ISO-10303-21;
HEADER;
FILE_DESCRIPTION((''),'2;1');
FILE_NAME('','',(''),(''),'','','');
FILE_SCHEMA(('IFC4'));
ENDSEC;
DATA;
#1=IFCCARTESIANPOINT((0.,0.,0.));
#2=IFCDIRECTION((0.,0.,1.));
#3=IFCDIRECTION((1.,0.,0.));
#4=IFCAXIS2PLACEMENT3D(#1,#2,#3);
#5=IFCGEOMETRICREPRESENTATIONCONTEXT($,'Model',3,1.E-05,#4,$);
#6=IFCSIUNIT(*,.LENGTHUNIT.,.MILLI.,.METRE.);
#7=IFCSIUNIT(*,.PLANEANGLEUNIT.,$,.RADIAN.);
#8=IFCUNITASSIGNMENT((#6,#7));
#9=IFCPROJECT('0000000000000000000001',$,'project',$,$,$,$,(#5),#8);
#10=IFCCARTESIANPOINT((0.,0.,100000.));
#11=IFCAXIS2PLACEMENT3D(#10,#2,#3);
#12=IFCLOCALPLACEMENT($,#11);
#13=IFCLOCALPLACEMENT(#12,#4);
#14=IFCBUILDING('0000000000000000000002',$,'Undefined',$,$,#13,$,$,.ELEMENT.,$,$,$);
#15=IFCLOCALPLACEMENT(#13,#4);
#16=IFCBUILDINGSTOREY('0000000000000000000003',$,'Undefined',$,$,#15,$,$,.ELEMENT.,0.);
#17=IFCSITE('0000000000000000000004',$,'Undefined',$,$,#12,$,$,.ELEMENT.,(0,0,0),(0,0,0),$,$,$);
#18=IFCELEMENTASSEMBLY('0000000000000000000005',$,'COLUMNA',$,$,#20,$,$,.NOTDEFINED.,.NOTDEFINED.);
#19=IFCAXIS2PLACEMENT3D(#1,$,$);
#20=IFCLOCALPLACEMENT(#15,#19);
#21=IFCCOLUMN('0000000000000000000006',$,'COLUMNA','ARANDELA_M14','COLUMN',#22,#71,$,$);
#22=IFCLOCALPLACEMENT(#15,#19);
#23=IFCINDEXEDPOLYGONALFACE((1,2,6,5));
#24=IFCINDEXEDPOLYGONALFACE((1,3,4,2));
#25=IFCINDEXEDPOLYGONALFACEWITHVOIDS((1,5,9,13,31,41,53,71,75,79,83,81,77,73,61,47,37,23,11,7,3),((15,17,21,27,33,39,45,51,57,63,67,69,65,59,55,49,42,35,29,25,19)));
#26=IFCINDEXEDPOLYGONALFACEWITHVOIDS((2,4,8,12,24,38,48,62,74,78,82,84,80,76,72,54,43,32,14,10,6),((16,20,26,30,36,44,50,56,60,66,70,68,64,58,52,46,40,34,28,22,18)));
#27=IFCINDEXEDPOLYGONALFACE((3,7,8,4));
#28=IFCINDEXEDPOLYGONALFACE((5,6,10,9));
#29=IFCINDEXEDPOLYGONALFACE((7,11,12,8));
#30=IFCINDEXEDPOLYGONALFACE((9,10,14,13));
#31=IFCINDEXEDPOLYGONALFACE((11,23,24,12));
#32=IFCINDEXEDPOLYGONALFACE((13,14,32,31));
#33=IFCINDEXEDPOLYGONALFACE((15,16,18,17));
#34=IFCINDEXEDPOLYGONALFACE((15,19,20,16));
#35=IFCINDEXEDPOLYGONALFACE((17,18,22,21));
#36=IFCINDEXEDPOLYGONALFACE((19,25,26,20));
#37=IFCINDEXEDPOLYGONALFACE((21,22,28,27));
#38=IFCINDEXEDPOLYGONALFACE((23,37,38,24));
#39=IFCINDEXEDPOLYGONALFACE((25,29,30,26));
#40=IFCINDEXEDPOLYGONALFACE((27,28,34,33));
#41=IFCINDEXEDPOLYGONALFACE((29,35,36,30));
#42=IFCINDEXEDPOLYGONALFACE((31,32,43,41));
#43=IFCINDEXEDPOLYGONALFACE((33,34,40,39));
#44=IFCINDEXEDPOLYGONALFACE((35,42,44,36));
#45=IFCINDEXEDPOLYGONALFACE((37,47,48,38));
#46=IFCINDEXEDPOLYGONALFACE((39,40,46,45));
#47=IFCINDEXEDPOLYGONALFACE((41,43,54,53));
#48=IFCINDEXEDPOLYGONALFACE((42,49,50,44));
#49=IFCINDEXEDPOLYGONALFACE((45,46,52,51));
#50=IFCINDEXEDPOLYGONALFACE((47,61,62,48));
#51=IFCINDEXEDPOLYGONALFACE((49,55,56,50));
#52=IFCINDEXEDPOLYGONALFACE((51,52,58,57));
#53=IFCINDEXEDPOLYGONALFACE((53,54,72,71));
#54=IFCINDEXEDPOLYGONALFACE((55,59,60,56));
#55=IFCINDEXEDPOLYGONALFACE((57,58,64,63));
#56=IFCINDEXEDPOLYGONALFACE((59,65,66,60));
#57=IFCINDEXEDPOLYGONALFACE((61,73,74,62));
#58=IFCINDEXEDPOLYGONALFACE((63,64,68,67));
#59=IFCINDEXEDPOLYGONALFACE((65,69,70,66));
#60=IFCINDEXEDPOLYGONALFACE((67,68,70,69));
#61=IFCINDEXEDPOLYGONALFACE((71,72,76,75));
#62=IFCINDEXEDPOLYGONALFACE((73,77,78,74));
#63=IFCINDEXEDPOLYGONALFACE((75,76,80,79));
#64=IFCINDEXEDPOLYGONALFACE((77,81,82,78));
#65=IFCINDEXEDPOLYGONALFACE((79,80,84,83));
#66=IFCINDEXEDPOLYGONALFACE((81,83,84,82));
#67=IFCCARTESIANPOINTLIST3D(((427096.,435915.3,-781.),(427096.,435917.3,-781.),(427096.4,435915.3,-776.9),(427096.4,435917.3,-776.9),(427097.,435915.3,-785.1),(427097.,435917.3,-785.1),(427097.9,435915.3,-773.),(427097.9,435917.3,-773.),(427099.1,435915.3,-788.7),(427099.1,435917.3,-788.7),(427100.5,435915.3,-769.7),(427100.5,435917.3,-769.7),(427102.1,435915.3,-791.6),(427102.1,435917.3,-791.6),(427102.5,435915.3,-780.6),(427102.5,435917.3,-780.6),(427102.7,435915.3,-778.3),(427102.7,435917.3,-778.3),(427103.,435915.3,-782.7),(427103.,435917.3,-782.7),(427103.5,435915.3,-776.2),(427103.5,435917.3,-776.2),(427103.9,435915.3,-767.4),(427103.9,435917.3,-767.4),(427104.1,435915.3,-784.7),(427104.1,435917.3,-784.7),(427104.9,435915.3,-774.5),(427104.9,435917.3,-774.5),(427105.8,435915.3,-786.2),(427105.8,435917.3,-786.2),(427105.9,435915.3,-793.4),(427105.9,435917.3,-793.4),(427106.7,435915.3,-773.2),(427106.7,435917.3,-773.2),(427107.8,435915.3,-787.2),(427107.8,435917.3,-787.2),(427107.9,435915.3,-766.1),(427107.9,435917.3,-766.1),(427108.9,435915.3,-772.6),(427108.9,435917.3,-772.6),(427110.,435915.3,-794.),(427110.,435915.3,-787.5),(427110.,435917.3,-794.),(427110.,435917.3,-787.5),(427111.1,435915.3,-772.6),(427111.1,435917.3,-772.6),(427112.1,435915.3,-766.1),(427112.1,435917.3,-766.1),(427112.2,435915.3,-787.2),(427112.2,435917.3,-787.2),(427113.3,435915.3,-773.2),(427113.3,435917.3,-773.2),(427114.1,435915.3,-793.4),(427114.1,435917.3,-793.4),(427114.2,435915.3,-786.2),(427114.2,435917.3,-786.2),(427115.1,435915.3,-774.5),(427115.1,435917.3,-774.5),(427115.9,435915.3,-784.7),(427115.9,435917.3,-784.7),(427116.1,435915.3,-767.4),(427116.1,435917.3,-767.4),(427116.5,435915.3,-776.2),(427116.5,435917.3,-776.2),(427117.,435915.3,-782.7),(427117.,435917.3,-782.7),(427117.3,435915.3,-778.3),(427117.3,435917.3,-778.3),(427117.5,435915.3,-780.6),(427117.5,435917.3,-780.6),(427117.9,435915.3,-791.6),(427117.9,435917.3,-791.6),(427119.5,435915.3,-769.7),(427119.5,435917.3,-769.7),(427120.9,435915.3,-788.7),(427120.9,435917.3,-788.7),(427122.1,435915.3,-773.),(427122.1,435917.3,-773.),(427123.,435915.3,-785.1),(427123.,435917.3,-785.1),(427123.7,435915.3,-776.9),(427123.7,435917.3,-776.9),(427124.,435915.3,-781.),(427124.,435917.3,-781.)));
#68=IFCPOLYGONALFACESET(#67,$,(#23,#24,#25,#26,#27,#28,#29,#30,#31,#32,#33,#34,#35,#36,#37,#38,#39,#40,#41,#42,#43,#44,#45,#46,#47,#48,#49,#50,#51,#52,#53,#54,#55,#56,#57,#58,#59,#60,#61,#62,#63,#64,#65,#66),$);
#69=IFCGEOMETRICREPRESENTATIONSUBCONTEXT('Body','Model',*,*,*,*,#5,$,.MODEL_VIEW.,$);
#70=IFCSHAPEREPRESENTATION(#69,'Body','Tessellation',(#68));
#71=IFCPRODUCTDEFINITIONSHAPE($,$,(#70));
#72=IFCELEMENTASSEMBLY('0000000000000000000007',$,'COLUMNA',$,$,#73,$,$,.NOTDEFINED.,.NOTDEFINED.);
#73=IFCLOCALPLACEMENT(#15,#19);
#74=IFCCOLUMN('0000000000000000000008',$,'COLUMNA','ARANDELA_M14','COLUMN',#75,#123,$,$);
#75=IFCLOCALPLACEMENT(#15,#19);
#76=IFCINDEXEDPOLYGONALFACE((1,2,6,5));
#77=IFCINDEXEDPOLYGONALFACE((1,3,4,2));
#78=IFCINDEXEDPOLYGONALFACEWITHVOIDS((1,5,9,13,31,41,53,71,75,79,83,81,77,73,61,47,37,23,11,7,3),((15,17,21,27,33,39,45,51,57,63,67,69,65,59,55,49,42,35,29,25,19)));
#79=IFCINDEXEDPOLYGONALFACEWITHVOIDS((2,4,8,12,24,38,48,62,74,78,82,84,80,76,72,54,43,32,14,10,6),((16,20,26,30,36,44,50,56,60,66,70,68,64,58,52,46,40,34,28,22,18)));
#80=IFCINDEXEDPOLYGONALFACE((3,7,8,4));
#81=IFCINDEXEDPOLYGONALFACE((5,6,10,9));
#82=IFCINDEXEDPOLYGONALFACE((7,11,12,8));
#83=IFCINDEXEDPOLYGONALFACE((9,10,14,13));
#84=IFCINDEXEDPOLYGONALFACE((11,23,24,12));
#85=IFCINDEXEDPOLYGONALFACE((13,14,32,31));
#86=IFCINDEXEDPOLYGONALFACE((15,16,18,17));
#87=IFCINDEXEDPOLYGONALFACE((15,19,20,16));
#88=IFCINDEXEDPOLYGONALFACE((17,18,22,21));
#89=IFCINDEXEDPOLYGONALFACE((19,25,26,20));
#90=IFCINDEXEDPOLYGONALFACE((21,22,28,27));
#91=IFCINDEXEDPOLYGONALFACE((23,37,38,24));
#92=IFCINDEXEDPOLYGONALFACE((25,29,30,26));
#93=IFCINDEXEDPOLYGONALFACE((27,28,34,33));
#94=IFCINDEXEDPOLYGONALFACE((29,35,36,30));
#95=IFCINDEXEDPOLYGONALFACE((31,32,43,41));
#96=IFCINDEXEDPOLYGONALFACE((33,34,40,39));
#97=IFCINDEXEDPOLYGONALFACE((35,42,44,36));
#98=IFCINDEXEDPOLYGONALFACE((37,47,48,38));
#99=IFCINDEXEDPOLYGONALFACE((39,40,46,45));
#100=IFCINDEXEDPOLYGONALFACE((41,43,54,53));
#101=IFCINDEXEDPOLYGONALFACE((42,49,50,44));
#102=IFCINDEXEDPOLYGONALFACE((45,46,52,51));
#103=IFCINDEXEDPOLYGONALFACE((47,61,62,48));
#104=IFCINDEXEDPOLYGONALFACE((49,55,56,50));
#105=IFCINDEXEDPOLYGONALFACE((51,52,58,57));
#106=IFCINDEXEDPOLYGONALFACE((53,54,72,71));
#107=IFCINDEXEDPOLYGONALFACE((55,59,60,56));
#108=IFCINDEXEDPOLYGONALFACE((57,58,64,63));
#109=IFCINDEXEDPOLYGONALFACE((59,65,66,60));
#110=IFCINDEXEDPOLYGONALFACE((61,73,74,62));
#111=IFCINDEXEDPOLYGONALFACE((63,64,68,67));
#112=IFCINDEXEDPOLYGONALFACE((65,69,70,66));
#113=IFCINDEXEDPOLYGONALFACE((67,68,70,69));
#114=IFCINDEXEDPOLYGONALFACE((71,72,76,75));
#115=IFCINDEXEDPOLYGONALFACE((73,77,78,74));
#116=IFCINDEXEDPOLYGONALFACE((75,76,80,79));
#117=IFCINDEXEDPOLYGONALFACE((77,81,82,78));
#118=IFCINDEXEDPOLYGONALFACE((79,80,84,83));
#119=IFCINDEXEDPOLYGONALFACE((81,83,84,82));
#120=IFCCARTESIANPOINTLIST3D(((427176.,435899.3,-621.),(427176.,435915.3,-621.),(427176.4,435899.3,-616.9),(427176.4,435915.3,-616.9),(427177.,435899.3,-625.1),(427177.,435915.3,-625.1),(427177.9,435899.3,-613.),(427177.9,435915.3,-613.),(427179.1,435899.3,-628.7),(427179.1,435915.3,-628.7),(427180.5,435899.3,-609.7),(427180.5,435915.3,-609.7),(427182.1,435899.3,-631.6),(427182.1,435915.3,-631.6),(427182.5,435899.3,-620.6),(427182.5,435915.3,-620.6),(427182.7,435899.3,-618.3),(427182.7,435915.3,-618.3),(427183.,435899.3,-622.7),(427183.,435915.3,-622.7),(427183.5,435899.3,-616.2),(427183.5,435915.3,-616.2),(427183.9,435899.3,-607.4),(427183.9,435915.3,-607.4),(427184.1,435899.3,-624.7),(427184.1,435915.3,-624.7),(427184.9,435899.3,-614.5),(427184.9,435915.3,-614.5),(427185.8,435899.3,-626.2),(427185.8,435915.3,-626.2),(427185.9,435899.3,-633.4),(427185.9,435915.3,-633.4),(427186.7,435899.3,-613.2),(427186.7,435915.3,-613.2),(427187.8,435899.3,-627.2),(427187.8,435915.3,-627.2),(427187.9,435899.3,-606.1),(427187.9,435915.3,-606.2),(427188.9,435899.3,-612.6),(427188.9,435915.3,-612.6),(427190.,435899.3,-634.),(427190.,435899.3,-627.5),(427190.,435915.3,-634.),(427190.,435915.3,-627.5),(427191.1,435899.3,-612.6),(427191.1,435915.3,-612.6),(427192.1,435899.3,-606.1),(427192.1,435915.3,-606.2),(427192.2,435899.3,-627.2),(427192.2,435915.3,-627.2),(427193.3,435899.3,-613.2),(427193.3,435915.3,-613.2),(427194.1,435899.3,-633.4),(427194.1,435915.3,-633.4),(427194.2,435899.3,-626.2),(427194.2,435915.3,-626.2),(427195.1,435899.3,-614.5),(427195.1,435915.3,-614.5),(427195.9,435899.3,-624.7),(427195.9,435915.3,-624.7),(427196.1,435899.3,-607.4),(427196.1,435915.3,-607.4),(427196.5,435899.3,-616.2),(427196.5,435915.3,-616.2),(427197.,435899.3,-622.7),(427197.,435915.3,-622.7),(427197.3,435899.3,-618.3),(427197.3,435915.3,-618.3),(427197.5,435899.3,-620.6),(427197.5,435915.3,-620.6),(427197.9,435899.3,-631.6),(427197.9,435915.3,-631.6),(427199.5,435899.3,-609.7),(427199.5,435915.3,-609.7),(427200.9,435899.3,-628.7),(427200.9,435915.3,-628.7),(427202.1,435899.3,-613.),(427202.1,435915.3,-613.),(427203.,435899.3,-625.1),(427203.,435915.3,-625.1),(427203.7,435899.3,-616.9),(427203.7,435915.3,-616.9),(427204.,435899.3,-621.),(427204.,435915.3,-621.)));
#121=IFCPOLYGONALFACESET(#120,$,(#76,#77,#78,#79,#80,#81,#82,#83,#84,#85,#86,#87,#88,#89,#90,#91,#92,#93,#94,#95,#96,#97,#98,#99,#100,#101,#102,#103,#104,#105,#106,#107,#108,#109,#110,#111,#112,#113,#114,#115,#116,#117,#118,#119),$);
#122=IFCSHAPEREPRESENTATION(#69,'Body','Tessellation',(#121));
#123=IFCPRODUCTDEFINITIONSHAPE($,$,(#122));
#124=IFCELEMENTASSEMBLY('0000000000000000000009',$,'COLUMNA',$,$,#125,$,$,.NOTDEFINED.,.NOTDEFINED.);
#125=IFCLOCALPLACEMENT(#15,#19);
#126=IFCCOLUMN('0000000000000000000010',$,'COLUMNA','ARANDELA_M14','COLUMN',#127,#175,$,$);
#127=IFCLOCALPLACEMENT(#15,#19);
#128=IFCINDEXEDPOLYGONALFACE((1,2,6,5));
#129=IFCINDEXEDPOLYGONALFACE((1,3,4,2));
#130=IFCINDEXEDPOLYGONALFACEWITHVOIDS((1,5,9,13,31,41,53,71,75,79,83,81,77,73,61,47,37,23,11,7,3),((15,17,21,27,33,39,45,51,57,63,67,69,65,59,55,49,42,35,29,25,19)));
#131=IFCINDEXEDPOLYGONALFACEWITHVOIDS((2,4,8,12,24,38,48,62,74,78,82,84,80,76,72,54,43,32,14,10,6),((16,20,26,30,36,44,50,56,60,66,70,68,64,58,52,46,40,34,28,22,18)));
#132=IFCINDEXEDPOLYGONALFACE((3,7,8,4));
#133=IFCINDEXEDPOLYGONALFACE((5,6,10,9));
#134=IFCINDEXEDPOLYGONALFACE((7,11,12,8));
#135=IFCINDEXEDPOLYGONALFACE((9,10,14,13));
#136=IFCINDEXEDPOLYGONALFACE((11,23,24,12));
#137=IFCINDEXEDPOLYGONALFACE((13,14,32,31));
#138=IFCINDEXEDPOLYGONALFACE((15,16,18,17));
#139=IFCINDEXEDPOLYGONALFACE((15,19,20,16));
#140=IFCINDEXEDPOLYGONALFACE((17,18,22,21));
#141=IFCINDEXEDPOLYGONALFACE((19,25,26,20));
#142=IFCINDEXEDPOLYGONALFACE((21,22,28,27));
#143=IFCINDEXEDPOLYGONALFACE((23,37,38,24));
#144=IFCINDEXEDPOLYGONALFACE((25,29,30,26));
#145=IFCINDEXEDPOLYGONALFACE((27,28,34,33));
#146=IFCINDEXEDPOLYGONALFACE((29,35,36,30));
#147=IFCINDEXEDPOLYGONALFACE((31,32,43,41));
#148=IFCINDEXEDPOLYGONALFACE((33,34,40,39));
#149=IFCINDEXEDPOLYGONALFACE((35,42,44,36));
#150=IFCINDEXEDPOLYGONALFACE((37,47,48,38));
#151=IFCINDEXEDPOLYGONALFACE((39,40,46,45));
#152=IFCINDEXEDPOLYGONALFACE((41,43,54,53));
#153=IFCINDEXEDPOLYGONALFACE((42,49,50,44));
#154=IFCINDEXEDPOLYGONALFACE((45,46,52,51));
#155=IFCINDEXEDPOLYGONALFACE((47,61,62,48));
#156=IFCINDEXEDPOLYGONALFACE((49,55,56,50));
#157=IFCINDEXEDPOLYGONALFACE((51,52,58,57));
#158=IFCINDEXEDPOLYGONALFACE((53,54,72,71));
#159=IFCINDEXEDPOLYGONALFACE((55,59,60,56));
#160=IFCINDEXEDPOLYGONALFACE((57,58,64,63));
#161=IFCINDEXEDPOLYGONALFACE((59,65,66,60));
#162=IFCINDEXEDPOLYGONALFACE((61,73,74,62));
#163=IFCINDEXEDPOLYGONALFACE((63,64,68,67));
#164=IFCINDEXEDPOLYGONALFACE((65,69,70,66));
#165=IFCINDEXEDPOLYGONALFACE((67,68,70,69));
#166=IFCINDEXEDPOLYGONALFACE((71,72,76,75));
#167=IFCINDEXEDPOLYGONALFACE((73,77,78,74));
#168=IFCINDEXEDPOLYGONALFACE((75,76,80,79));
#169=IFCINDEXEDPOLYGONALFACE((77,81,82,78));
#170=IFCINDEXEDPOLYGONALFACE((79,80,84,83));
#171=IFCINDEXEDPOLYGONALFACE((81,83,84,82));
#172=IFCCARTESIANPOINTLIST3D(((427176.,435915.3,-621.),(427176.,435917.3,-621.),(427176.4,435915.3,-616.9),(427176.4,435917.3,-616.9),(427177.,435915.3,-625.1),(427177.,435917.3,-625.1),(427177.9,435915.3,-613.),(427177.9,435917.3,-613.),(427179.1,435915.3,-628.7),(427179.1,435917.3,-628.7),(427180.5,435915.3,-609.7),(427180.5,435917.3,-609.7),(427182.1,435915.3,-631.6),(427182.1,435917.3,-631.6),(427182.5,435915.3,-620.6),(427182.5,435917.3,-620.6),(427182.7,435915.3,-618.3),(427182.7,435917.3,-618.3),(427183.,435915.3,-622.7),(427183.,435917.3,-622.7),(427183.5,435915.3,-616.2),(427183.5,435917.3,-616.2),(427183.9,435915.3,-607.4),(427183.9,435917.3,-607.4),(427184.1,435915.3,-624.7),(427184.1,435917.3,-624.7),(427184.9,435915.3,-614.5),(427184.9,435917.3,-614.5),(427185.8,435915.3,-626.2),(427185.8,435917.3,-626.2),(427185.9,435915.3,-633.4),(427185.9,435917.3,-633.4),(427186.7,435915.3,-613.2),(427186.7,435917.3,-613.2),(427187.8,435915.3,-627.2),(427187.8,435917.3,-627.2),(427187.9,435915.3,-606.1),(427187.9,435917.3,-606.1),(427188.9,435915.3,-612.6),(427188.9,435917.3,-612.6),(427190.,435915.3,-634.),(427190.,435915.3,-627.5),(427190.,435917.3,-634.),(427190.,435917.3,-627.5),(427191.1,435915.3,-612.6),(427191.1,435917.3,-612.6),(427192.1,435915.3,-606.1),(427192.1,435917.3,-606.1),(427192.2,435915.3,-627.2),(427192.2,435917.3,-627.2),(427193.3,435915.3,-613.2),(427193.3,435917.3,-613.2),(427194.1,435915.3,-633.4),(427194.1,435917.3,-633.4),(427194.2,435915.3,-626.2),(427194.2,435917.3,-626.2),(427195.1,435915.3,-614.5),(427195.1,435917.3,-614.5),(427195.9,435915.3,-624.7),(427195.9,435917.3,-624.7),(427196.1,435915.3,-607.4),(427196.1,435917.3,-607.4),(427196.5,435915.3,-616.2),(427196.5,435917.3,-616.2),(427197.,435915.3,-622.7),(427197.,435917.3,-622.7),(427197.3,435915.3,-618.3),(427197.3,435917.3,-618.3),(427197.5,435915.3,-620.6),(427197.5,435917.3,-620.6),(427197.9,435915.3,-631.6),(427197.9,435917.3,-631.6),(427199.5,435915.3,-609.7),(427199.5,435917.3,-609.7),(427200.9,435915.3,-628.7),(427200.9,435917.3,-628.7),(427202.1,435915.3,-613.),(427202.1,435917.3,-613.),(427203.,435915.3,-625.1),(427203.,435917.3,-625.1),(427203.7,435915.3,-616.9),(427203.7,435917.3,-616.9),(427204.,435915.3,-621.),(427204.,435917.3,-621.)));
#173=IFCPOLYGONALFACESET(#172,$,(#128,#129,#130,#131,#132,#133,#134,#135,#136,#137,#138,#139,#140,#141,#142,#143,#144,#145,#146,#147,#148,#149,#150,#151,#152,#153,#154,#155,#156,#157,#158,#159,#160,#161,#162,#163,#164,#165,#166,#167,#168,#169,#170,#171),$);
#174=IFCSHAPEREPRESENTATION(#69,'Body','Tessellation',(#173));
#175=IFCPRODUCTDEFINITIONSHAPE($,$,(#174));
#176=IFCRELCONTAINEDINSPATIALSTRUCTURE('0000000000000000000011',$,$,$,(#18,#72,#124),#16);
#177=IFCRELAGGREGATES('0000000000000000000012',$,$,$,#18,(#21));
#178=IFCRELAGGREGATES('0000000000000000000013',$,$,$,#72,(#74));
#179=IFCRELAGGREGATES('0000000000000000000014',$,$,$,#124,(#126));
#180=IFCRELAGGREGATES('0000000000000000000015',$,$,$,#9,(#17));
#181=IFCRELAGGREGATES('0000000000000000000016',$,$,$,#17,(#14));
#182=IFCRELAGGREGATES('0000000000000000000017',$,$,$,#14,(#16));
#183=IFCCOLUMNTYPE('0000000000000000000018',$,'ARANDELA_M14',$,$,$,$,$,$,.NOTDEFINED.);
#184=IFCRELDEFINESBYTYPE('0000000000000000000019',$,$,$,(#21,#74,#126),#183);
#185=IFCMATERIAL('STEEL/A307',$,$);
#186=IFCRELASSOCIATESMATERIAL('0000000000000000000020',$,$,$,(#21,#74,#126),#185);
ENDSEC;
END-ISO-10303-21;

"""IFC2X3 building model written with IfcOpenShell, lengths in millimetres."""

from ifc_helpers import new_model, si_unit, frame, origin_with_axes, origin_2d_with_axis, place, context, subcontext, project, spatial, hollow_circle, extrude, material, type_object, element, aggregate, save


model = new_model("IFC2X3")

# Units and contexts
model_context = context("Model", 3, precision=1e-05, world=origin_with_axes())
body_context = subcontext(model_context, "Body", "Model", "MODEL_VIEW")
ifc_project = project(units=[si_unit("LENGTHUNIT", "METRE", prefix="MILLI"), si_unit("PLANEANGLEUNIT", "RADIAN")], contexts=[model_context])

# Site, building, storey
site_placement = place(None, frame((0.0, 0.0, 100000.0), z_axis=(0.0, 0.0, 1.0), x_axis=(1.0, 0.0, 0.0)))
site = spatial("IfcSite", under=ifc_project, at=site_placement, Name="Undefined", CompositionType="ELEMENT", RefLatitude=(0, 0, 0), RefLongitude=(0, 0, 0))
building_placement = place(site_placement, origin_with_axes())
building = spatial("IfcBuilding", under=site, at=building_placement, Name="Undefined", CompositionType="ELEMENT")
storey_placement = place(building_placement, origin_with_axes())
storey = spatial("IfcBuildingStorey", under=building, at=storey_placement, Name="Undefined", CompositionType="ELEMENT", Elevation=0.0)

# Element assemblies, columns
ifc_material_1 = material(Name="STEEL/A307")
column_type = type_object("IfcColumnType", Name="ARANDELA_M14", PredefinedType="NOTDEFINED")
assembly_1_placement = place(storey_placement, origin_with_axes())
assembly_1 = element("IfcElementAssembly", 1, at=assembly_1_placement, inside=storey, Name="COLUMNA", AssemblyPlace="NOTDEFINED", PredefinedType="NOTDEFINED")
column_1_placement = place(assembly_1_placement, frame((427110.0, 435917.3, -780.0), z_axis=(0.0, -1.0, 0.000285), x_axis=(-1.0, 0.0, 0.0)))
column_1 = element("IfcColumn", 2, at=column_1_placement, type_object=column_type, material=ifc_material_1, Name="COLUMNA", Description="ARANDELA_M14", ObjectType="COLUMN", context=body_context, shape_type="SweptSolid", body=[
    extrude(hollow_circle(Radius=14.0, WallThickness=6.5, at=origin_2d_with_axis()), frame((0.0, 0.0, 2.0), z_axis=(0.0, 0.0, -1.0), x_axis=(0.0, 1.0, 0.0)), (0.0, 0.0, 1.0), 2.0),
])
aggregate(assembly_1, [column_1])
assembly_2_placement = place(storey_placement, origin_with_axes())
assembly_2 = element("IfcElementAssembly", 3, at=assembly_2_placement, inside=storey, Name="COLUMNA", AssemblyPlace="NOTDEFINED", PredefinedType="NOTDEFINED")
column_2_placement = place(assembly_2_placement, frame((427190.0, 435915.3, -620.0), z_axis=(0.0, -1.0, 0.000285), x_axis=(-1.0, 0.0, 0.0)))
column_2 = element("IfcColumn", 4, at=column_2_placement, type_object=column_type, material=ifc_material_1, Name="COLUMNA", Description="ARANDELA_M14", ObjectType="COLUMN", context=body_context, shape_type="SweptSolid", body=[
    extrude(hollow_circle(Radius=14.0, WallThickness=6.5, at=origin_2d_with_axis()), frame((0.0, 0.0, 16.0), z_axis=(0.0, 0.0, -1.0), x_axis=(0.0, 1.0, 0.0)), (0.0, 0.0, 1.0), 16.0),
])
aggregate(assembly_2, [column_2])
assembly_3_placement = place(storey_placement, origin_with_axes())
assembly_3 = element("IfcElementAssembly", 5, at=assembly_3_placement, inside=storey, Name="COLUMNA", AssemblyPlace="NOTDEFINED", PredefinedType="NOTDEFINED")
column_3_placement = place(assembly_3_placement, frame((427190.0, 435917.3, -620.0), z_axis=(0.0, -1.0, 0.000285), x_axis=(-1.0, 0.0, 0.0)))
column_3 = element("IfcColumn", 6, at=column_3_placement, type_object=column_type, material=ifc_material_1, Name="COLUMNA", Description="ARANDELA_M14", ObjectType="COLUMN", context=body_context, shape_type="SweptSolid", body=[
    extrude(hollow_circle(Radius=14.0, WallThickness=6.5, at=origin_2d_with_axis()), frame((0.0, 0.0, 2.0), z_axis=(0.0, 0.0, -1.0), x_axis=(0.0, 1.0, 0.0)), (0.0, 0.0, 1.0), 2.0),
])
aggregate(assembly_3, [column_3])

save(model, "model.ifc")
